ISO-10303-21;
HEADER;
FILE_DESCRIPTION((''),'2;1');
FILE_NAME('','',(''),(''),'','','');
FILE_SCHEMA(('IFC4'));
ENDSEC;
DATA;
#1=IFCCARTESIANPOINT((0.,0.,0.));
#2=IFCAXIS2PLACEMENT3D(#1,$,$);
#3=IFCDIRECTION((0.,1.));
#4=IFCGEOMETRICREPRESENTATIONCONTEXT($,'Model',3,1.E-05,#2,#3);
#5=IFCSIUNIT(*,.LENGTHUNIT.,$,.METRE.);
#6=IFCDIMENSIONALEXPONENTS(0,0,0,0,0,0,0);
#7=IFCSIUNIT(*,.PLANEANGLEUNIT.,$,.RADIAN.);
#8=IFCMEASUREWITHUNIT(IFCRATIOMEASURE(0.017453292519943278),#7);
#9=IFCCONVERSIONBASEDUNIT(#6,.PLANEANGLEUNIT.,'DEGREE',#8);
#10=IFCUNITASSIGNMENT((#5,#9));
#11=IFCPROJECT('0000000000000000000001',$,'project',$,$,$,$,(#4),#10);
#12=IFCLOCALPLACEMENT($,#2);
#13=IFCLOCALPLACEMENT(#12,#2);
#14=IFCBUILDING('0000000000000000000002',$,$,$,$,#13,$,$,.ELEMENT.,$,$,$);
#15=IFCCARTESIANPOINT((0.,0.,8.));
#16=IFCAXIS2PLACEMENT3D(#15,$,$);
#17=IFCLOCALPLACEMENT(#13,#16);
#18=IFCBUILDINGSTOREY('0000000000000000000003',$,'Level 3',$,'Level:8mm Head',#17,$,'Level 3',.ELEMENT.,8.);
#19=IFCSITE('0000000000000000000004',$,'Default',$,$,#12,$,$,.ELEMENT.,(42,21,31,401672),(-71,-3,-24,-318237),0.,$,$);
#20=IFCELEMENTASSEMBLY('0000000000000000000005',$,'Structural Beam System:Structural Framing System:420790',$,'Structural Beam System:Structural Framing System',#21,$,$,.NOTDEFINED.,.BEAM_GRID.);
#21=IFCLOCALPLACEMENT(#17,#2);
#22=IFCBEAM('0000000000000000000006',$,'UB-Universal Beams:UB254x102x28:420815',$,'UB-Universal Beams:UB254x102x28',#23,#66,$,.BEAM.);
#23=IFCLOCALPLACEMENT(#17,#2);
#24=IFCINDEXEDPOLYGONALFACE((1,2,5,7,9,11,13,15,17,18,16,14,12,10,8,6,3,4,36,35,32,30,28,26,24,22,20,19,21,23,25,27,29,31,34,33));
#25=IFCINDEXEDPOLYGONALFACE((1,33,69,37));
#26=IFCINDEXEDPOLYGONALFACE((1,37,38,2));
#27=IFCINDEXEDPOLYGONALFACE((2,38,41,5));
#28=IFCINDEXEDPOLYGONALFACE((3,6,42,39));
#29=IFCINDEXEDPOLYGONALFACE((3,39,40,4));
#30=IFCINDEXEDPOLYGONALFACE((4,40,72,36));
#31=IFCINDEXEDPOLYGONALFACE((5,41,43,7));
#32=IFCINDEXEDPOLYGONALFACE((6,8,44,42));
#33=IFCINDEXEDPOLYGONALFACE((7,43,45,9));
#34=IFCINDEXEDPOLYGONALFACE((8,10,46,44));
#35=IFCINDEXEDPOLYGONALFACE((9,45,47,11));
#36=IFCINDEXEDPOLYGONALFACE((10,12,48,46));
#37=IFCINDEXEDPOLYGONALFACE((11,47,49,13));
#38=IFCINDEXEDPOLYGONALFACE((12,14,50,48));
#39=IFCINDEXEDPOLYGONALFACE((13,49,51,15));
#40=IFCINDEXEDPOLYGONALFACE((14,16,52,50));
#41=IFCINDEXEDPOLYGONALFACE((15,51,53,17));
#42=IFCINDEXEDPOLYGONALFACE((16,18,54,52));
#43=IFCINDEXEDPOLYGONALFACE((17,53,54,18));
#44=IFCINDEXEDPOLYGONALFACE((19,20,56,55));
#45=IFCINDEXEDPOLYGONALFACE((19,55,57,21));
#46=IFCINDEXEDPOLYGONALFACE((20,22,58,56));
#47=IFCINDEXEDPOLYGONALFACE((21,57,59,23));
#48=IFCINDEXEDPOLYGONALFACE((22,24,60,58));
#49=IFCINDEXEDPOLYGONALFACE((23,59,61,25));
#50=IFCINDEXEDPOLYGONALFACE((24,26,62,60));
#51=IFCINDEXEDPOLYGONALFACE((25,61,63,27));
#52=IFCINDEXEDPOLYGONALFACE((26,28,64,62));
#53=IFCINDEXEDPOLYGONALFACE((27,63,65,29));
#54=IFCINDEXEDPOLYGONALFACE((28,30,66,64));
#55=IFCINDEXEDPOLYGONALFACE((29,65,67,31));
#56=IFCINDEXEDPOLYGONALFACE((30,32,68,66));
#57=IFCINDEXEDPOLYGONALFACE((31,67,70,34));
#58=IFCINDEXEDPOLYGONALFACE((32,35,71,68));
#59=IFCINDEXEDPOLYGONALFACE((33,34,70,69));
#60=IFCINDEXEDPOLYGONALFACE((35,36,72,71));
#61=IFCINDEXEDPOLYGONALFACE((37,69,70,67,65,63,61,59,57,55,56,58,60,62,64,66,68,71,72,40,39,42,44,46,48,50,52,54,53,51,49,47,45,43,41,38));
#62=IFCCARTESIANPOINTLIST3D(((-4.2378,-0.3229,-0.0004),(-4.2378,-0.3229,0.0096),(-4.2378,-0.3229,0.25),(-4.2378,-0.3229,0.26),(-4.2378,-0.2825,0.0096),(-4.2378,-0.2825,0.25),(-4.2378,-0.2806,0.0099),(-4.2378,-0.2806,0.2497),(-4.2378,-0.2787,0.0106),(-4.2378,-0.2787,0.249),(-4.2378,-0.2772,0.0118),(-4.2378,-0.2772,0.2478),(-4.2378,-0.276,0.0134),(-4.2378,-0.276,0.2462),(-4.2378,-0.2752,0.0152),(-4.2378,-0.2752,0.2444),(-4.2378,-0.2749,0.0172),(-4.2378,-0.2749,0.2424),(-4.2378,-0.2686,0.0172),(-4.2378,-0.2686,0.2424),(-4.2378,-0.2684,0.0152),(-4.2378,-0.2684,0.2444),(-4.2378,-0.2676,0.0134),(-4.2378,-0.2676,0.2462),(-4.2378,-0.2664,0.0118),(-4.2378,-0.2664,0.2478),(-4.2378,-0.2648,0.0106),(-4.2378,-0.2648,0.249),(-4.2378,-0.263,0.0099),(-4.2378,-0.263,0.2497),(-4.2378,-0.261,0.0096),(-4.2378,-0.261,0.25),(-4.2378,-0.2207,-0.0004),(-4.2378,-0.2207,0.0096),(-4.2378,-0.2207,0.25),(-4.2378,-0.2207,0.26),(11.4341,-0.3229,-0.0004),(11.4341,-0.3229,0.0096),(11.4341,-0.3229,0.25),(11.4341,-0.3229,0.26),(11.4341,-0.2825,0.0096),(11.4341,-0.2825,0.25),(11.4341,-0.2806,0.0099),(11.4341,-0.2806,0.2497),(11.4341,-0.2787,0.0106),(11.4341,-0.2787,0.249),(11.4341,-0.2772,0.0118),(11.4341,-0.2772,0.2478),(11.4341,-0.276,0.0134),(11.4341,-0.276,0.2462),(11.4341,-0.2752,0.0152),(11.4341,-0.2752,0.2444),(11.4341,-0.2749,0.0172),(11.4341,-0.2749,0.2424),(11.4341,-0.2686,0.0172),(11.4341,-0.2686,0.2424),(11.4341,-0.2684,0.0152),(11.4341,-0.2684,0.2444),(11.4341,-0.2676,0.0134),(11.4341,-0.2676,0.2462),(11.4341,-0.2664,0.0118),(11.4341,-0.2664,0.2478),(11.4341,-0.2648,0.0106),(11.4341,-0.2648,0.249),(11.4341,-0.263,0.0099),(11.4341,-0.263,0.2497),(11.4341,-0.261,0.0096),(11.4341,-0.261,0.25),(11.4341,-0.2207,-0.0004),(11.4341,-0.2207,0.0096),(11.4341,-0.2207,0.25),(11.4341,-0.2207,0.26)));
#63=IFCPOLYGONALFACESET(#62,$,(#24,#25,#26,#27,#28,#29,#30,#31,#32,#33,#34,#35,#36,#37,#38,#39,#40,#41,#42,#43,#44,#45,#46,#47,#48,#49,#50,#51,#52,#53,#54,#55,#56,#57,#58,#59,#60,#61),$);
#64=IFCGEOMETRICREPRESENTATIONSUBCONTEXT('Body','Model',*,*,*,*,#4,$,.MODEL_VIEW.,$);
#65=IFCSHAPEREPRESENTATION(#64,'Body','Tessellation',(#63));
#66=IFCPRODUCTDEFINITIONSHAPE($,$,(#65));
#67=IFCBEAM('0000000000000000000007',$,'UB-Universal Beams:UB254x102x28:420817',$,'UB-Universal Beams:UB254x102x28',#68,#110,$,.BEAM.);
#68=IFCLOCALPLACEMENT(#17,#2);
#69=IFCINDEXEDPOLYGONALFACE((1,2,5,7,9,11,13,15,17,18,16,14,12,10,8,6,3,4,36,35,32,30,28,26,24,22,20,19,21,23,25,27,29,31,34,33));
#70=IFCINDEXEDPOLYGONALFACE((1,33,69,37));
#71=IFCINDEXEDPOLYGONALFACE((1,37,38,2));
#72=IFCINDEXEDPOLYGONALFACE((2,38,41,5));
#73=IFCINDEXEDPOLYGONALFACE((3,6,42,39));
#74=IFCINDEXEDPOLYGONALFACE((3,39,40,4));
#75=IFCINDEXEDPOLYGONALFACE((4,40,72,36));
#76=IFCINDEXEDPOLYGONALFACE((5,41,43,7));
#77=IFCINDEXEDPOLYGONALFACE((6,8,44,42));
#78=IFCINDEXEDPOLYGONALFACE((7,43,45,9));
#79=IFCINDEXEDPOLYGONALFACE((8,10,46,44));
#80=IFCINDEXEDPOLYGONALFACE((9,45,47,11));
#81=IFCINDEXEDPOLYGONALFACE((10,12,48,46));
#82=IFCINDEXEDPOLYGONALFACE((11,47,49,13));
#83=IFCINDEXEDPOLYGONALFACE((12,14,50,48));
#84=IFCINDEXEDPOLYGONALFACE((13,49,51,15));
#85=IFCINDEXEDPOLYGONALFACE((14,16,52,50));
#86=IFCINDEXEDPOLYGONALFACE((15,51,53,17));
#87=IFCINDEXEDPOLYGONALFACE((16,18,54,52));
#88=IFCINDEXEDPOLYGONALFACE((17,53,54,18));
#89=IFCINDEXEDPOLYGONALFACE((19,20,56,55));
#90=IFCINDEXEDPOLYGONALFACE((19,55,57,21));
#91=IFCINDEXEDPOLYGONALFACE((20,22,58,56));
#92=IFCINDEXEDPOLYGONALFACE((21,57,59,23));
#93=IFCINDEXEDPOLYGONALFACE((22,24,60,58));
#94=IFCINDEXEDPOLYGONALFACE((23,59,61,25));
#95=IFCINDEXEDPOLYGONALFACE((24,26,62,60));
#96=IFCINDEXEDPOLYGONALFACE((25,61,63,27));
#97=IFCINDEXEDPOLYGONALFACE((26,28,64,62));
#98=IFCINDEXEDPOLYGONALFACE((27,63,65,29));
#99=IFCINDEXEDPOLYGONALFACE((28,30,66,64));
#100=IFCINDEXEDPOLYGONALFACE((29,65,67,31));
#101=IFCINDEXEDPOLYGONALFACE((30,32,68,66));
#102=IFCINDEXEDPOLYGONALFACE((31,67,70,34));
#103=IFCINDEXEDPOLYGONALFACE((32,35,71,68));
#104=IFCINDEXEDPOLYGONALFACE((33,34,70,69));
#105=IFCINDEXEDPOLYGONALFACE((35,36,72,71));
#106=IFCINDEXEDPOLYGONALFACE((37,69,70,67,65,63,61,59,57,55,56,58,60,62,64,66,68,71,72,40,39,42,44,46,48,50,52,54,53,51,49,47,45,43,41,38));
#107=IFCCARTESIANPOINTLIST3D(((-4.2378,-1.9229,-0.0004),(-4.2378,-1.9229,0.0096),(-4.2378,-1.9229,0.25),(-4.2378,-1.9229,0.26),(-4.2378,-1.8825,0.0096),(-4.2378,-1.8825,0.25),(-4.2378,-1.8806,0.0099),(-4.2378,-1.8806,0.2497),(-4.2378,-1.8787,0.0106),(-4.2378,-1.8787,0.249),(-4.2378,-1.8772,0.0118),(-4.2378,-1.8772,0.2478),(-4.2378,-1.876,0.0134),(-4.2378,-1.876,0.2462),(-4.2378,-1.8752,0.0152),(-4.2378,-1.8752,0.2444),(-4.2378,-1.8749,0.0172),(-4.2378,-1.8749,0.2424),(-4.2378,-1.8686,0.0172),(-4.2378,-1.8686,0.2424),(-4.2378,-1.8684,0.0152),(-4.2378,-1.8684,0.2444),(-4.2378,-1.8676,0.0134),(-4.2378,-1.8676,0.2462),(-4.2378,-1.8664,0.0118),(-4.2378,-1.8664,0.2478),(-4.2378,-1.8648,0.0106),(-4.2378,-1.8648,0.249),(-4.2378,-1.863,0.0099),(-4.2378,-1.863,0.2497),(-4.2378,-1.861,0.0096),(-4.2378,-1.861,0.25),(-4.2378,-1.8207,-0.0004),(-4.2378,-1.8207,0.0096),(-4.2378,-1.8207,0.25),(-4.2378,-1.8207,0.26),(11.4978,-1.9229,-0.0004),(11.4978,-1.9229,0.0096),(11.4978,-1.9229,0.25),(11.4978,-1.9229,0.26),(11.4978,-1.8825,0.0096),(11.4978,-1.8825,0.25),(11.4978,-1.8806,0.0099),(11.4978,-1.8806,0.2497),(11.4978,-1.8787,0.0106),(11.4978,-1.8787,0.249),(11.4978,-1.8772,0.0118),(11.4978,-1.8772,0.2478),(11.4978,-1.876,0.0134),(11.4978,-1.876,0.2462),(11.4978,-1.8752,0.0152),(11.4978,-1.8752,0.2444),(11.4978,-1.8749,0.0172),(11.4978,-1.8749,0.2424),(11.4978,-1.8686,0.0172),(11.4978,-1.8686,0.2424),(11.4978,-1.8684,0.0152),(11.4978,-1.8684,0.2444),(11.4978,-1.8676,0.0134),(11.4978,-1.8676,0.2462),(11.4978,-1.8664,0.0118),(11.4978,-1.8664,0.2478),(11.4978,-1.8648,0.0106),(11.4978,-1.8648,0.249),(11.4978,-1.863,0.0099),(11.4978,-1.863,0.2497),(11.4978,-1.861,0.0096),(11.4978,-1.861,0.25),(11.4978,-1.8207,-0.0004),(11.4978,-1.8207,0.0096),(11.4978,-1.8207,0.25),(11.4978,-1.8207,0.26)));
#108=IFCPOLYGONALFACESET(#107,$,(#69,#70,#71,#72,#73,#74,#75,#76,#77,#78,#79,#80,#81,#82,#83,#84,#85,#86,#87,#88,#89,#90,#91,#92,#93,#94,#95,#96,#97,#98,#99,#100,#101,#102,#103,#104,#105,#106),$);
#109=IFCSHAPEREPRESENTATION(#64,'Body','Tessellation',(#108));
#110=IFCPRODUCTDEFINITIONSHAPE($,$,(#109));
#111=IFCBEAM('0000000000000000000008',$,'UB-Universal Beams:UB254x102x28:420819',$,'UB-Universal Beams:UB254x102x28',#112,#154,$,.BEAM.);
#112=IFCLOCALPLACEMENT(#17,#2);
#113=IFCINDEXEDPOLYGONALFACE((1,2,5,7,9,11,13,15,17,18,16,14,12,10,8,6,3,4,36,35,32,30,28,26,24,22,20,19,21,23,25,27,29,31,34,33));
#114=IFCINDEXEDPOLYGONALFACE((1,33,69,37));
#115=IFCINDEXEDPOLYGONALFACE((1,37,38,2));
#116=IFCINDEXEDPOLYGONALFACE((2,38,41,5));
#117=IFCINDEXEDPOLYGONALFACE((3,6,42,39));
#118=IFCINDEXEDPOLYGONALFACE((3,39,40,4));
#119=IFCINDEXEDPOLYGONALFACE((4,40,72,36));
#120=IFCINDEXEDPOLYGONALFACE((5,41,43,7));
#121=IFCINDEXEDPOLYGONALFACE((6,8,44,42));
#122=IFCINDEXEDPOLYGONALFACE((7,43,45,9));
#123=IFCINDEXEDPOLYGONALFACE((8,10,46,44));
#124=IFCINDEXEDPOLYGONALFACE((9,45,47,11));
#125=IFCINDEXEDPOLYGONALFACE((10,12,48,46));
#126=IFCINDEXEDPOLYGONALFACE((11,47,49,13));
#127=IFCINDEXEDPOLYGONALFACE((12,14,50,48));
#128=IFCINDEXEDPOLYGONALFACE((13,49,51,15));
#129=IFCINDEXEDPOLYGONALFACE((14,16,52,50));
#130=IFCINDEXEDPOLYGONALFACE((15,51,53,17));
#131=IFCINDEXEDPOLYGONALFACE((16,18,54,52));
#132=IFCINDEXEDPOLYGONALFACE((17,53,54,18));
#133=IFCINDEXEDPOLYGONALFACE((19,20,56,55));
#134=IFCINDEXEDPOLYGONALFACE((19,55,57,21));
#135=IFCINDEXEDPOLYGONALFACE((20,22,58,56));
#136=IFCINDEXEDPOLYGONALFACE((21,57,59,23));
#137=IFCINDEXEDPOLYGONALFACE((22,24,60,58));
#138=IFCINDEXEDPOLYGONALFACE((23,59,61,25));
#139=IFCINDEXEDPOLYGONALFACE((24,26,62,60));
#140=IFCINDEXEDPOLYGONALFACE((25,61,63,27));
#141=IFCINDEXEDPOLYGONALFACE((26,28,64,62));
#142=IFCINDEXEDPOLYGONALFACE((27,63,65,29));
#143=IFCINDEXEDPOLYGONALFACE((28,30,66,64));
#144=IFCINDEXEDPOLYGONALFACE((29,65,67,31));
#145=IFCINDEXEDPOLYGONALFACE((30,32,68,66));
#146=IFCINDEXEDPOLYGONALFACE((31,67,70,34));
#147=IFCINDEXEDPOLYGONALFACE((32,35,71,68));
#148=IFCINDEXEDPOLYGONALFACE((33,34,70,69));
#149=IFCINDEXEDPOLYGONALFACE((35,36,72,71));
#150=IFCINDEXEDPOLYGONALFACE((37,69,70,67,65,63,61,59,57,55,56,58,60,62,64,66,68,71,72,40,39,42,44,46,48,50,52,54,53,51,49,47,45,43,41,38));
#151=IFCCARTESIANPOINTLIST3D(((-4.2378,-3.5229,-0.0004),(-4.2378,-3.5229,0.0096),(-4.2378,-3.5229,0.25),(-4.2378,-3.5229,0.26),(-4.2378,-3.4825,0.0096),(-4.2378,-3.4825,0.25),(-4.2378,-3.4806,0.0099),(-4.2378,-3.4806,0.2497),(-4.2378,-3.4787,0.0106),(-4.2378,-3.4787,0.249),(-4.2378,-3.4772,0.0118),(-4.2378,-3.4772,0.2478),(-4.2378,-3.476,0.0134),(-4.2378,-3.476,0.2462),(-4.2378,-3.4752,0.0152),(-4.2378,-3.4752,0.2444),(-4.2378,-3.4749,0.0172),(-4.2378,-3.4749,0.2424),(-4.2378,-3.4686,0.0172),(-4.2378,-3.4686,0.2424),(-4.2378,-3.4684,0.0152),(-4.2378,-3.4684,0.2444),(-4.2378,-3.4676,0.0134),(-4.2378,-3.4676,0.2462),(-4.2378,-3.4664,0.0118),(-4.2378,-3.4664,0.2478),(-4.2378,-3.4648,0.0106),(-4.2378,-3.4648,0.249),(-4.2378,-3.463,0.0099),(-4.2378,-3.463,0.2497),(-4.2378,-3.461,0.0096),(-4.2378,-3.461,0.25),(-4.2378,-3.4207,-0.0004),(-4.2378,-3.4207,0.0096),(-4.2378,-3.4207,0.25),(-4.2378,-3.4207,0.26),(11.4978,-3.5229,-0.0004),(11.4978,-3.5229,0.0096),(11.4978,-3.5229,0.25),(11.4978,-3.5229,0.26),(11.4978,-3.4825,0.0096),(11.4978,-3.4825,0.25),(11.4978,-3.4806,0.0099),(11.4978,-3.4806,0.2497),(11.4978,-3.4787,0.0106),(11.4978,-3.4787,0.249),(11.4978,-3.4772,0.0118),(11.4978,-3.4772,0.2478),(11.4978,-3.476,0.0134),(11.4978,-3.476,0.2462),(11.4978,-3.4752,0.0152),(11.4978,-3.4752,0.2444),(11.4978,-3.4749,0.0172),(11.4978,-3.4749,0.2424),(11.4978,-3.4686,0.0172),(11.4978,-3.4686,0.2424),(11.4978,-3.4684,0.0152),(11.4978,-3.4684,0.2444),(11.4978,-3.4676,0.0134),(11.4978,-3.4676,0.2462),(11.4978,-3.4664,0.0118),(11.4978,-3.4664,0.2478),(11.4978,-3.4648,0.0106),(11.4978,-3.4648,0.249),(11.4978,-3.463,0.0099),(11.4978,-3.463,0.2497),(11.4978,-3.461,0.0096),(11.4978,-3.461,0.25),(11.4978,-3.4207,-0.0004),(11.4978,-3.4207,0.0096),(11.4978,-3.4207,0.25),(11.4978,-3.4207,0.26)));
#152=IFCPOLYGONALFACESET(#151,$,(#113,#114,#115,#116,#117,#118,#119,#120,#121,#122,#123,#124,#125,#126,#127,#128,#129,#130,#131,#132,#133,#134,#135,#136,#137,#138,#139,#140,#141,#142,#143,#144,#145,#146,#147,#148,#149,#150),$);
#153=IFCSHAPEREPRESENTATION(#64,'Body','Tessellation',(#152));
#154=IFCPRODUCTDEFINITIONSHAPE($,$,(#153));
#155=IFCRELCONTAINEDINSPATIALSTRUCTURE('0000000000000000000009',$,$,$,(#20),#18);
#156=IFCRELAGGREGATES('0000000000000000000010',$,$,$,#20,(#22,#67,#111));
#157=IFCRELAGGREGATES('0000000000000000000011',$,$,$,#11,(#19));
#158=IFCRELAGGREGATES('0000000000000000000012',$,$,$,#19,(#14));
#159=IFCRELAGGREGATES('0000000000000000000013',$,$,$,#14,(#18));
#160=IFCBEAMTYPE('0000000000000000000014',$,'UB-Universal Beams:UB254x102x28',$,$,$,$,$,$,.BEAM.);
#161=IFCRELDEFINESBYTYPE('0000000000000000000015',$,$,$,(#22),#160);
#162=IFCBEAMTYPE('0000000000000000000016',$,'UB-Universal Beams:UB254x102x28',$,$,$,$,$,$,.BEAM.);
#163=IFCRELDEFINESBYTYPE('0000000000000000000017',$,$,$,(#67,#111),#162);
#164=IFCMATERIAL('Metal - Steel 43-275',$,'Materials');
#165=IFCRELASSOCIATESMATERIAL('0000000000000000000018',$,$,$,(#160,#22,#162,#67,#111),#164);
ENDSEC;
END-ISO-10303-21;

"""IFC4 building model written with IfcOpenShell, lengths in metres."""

from ifc_helpers import new_model, entity, si_unit, converted_unit, direction, frame, origin, place, context, subcontext, project, spatial, line, arc, indexed_curve, outline, extrude, source, transform, mapped, material, type_object, type_shapes, element, aggregate, save


model = new_model("IFC4")

# Units and contexts
model_context = context("Model", 3, precision=1e-05, world=origin(), true_north=direction((0.0, 1.0)))
body_context = subcontext(model_context, "Body", "Model", "MODEL_VIEW")
ifc_project = project(units=[si_unit("LENGTHUNIT", "METRE"), converted_unit("PLANEANGLEUNIT", "DEGREE", entity("IfcRatioMeasure", 0.017453292519943278), si_unit("PLANEANGLEUNIT", "RADIAN"), dimensions=[0, 0, 0, 0, 0, 0, 0])], contexts=[model_context])

# Site, building, storey
site_placement = place(None, origin())
site = spatial("IfcSite", under=ifc_project, at=site_placement, Name="Default", CompositionType="ELEMENT", RefLatitude=(42, 21, 31, 401672), RefLongitude=(-71, -3, -24, -318237), RefElevation=0.0)
building_placement = place(site_placement, origin())
building = spatial("IfcBuilding", under=site, at=building_placement, CompositionType="ELEMENT")
storey_placement = place(building_placement, frame((0.0, 0.0, 8.0)))
storey = spatial("IfcBuildingStorey", under=building, at=storey_placement, Name="Level 3", ObjectType="Level:8mm Head", LongName="Level 3", CompositionType="ELEMENT", Elevation=8.0)

# Shared definitions
ifc_material_1 = material(Name="Metal - Steel 43-275", Category="Materials")

# Element assembly, beams
assembly_placement = place(storey_placement, origin())
assembly = element("IfcElementAssembly", 1, at=assembly_placement, inside=storey, Name="Structural Beam System:Structural Framing System:420790", ObjectType="Structural Beam System:Structural Framing System", AssemblyPlace="NOTDEFINED", PredefinedType="BEAM_GRID")
beam_type_1 = type_object("IfcBeamType", Name="UB-Universal Beams:UB254x102x28", PredefinedType="BEAM", material=ifc_material_1)
shared_shape_1 = source(origin(), body_context, "Body", "SweptSolid", [
    extrude(outline(indexed_curve([(-0.1302, -0.0511), (-0.1202, -0.0511), (-0.1202, -0.0107), (-0.118, -0.0054), (-0.1126, -0.0031), (0.1126, -0.0031), (0.118, -0.0054), (0.1202, -0.0107), (0.1202, -0.0511), (0.1302, -0.0511), (0.1302, 0.0511), (0.1202, 0.0511), (0.1202, 0.0108), (0.118, 0.0054), (0.1126, 0.0032), (-0.1126, 0.0032), (-0.118, 0.0054), (-0.1202, 0.0108), (-0.1202, 0.0511), (-0.1302, 0.0511)], segments=[line(1, 2, 3), arc(3, 4, 5), line(5, 6), arc(6, 7, 8), line(8, 9, 10, 11, 12, 13), arc(13, 14, 15), line(15, 16), arc(16, 17, 18), line(18, 19, 20, 1)], self_intersect=False)), frame((-7.8818, 0.0, 0.0), z_axis=(1.0, 0.0, 0.0), x_axis=(0.0, 0.0, -1.0)), (0.0, 0.0, 1.0), 15.6719),
])
type_shapes(beam_type_1, [shared_shape_1])
beam_1_placement = place(assembly_placement, frame((3.644, -0.2718, 0.1298)))
beam_1 = element("IfcBeam", 2, at=beam_1_placement, type_object=beam_type_1, material=ifc_material_1, Name="UB-Universal Beams:UB254x102x28:420815", ObjectType="UB-Universal Beams:UB254x102x28", PredefinedType="BEAM", context=body_context, shape_type="MappedRepresentation", body=[
    mapped(shared_shape_1, transform((0.0, 0.0, 0.0), scale=1.0)),
])
beam_type_2 = type_object("IfcBeamType", Name="UB-Universal Beams:UB254x102x28", PredefinedType="BEAM", material=ifc_material_1)
shared_shape_2 = source(origin(), body_context, "Body", "SweptSolid", [
    extrude(outline(indexed_curve([(-0.1302, -0.0511), (-0.1202, -0.0511), (-0.1202, -0.0107), (-0.118, -0.0054), (-0.1126, -0.0031), (0.1126, -0.0031), (0.118, -0.0054), (0.1202, -0.0107), (0.1202, -0.0511), (0.1302, -0.0511), (0.1302, 0.0511), (0.1202, 0.0511), (0.1202, 0.0108), (0.118, 0.0054), (0.1126, 0.0032), (-0.1126, 0.0032), (-0.118, 0.0054), (-0.1202, 0.0108), (-0.1202, 0.0511), (-0.1302, 0.0511)], segments=[line(1, 2, 3), arc(3, 4, 5), line(5, 6), arc(6, 7, 8), line(8, 9, 10, 11, 12, 13), arc(13, 14, 15), line(15, 16), arc(16, 17, 18), line(18, 19, 20, 1)], self_intersect=False)), frame((-7.8373, 0.0, 0.0), z_axis=(1.0, 0.0, 0.0), x_axis=(0.0, 0.0, -1.0)), (0.0, 0.0, 1.0), 15.7356),
])
type_shapes(beam_type_2, [shared_shape_2])
beam_2_placement = place(assembly_placement, frame((3.5995, -1.8718, 0.1298)))
beam_2 = element("IfcBeam", 3, at=beam_2_placement, type_object=beam_type_2, material=ifc_material_1, Name="UB-Universal Beams:UB254x102x28:420817", ObjectType="UB-Universal Beams:UB254x102x28", PredefinedType="BEAM", context=body_context, shape_type="MappedRepresentation", body=[
    mapped(shared_shape_2, transform((0.0, 0.0, 0.0), scale=1.0)),
])
beam_3_placement = place(assembly_placement, frame((3.5995, -3.4718, 0.1298)))
beam_3 = element("IfcBeam", 4, at=beam_3_placement, type_object=beam_type_2, material=ifc_material_1, Name="UB-Universal Beams:UB254x102x28:420819", ObjectType="UB-Universal Beams:UB254x102x28", PredefinedType="BEAM", context=body_context, shape_type="MappedRepresentation", body=[
    mapped(shared_shape_2, transform((0.0, 0.0, 0.0), scale=1.0)),
])
aggregate(assembly, [beam_1, beam_2, beam_3])

save(model, "model.ifc")
